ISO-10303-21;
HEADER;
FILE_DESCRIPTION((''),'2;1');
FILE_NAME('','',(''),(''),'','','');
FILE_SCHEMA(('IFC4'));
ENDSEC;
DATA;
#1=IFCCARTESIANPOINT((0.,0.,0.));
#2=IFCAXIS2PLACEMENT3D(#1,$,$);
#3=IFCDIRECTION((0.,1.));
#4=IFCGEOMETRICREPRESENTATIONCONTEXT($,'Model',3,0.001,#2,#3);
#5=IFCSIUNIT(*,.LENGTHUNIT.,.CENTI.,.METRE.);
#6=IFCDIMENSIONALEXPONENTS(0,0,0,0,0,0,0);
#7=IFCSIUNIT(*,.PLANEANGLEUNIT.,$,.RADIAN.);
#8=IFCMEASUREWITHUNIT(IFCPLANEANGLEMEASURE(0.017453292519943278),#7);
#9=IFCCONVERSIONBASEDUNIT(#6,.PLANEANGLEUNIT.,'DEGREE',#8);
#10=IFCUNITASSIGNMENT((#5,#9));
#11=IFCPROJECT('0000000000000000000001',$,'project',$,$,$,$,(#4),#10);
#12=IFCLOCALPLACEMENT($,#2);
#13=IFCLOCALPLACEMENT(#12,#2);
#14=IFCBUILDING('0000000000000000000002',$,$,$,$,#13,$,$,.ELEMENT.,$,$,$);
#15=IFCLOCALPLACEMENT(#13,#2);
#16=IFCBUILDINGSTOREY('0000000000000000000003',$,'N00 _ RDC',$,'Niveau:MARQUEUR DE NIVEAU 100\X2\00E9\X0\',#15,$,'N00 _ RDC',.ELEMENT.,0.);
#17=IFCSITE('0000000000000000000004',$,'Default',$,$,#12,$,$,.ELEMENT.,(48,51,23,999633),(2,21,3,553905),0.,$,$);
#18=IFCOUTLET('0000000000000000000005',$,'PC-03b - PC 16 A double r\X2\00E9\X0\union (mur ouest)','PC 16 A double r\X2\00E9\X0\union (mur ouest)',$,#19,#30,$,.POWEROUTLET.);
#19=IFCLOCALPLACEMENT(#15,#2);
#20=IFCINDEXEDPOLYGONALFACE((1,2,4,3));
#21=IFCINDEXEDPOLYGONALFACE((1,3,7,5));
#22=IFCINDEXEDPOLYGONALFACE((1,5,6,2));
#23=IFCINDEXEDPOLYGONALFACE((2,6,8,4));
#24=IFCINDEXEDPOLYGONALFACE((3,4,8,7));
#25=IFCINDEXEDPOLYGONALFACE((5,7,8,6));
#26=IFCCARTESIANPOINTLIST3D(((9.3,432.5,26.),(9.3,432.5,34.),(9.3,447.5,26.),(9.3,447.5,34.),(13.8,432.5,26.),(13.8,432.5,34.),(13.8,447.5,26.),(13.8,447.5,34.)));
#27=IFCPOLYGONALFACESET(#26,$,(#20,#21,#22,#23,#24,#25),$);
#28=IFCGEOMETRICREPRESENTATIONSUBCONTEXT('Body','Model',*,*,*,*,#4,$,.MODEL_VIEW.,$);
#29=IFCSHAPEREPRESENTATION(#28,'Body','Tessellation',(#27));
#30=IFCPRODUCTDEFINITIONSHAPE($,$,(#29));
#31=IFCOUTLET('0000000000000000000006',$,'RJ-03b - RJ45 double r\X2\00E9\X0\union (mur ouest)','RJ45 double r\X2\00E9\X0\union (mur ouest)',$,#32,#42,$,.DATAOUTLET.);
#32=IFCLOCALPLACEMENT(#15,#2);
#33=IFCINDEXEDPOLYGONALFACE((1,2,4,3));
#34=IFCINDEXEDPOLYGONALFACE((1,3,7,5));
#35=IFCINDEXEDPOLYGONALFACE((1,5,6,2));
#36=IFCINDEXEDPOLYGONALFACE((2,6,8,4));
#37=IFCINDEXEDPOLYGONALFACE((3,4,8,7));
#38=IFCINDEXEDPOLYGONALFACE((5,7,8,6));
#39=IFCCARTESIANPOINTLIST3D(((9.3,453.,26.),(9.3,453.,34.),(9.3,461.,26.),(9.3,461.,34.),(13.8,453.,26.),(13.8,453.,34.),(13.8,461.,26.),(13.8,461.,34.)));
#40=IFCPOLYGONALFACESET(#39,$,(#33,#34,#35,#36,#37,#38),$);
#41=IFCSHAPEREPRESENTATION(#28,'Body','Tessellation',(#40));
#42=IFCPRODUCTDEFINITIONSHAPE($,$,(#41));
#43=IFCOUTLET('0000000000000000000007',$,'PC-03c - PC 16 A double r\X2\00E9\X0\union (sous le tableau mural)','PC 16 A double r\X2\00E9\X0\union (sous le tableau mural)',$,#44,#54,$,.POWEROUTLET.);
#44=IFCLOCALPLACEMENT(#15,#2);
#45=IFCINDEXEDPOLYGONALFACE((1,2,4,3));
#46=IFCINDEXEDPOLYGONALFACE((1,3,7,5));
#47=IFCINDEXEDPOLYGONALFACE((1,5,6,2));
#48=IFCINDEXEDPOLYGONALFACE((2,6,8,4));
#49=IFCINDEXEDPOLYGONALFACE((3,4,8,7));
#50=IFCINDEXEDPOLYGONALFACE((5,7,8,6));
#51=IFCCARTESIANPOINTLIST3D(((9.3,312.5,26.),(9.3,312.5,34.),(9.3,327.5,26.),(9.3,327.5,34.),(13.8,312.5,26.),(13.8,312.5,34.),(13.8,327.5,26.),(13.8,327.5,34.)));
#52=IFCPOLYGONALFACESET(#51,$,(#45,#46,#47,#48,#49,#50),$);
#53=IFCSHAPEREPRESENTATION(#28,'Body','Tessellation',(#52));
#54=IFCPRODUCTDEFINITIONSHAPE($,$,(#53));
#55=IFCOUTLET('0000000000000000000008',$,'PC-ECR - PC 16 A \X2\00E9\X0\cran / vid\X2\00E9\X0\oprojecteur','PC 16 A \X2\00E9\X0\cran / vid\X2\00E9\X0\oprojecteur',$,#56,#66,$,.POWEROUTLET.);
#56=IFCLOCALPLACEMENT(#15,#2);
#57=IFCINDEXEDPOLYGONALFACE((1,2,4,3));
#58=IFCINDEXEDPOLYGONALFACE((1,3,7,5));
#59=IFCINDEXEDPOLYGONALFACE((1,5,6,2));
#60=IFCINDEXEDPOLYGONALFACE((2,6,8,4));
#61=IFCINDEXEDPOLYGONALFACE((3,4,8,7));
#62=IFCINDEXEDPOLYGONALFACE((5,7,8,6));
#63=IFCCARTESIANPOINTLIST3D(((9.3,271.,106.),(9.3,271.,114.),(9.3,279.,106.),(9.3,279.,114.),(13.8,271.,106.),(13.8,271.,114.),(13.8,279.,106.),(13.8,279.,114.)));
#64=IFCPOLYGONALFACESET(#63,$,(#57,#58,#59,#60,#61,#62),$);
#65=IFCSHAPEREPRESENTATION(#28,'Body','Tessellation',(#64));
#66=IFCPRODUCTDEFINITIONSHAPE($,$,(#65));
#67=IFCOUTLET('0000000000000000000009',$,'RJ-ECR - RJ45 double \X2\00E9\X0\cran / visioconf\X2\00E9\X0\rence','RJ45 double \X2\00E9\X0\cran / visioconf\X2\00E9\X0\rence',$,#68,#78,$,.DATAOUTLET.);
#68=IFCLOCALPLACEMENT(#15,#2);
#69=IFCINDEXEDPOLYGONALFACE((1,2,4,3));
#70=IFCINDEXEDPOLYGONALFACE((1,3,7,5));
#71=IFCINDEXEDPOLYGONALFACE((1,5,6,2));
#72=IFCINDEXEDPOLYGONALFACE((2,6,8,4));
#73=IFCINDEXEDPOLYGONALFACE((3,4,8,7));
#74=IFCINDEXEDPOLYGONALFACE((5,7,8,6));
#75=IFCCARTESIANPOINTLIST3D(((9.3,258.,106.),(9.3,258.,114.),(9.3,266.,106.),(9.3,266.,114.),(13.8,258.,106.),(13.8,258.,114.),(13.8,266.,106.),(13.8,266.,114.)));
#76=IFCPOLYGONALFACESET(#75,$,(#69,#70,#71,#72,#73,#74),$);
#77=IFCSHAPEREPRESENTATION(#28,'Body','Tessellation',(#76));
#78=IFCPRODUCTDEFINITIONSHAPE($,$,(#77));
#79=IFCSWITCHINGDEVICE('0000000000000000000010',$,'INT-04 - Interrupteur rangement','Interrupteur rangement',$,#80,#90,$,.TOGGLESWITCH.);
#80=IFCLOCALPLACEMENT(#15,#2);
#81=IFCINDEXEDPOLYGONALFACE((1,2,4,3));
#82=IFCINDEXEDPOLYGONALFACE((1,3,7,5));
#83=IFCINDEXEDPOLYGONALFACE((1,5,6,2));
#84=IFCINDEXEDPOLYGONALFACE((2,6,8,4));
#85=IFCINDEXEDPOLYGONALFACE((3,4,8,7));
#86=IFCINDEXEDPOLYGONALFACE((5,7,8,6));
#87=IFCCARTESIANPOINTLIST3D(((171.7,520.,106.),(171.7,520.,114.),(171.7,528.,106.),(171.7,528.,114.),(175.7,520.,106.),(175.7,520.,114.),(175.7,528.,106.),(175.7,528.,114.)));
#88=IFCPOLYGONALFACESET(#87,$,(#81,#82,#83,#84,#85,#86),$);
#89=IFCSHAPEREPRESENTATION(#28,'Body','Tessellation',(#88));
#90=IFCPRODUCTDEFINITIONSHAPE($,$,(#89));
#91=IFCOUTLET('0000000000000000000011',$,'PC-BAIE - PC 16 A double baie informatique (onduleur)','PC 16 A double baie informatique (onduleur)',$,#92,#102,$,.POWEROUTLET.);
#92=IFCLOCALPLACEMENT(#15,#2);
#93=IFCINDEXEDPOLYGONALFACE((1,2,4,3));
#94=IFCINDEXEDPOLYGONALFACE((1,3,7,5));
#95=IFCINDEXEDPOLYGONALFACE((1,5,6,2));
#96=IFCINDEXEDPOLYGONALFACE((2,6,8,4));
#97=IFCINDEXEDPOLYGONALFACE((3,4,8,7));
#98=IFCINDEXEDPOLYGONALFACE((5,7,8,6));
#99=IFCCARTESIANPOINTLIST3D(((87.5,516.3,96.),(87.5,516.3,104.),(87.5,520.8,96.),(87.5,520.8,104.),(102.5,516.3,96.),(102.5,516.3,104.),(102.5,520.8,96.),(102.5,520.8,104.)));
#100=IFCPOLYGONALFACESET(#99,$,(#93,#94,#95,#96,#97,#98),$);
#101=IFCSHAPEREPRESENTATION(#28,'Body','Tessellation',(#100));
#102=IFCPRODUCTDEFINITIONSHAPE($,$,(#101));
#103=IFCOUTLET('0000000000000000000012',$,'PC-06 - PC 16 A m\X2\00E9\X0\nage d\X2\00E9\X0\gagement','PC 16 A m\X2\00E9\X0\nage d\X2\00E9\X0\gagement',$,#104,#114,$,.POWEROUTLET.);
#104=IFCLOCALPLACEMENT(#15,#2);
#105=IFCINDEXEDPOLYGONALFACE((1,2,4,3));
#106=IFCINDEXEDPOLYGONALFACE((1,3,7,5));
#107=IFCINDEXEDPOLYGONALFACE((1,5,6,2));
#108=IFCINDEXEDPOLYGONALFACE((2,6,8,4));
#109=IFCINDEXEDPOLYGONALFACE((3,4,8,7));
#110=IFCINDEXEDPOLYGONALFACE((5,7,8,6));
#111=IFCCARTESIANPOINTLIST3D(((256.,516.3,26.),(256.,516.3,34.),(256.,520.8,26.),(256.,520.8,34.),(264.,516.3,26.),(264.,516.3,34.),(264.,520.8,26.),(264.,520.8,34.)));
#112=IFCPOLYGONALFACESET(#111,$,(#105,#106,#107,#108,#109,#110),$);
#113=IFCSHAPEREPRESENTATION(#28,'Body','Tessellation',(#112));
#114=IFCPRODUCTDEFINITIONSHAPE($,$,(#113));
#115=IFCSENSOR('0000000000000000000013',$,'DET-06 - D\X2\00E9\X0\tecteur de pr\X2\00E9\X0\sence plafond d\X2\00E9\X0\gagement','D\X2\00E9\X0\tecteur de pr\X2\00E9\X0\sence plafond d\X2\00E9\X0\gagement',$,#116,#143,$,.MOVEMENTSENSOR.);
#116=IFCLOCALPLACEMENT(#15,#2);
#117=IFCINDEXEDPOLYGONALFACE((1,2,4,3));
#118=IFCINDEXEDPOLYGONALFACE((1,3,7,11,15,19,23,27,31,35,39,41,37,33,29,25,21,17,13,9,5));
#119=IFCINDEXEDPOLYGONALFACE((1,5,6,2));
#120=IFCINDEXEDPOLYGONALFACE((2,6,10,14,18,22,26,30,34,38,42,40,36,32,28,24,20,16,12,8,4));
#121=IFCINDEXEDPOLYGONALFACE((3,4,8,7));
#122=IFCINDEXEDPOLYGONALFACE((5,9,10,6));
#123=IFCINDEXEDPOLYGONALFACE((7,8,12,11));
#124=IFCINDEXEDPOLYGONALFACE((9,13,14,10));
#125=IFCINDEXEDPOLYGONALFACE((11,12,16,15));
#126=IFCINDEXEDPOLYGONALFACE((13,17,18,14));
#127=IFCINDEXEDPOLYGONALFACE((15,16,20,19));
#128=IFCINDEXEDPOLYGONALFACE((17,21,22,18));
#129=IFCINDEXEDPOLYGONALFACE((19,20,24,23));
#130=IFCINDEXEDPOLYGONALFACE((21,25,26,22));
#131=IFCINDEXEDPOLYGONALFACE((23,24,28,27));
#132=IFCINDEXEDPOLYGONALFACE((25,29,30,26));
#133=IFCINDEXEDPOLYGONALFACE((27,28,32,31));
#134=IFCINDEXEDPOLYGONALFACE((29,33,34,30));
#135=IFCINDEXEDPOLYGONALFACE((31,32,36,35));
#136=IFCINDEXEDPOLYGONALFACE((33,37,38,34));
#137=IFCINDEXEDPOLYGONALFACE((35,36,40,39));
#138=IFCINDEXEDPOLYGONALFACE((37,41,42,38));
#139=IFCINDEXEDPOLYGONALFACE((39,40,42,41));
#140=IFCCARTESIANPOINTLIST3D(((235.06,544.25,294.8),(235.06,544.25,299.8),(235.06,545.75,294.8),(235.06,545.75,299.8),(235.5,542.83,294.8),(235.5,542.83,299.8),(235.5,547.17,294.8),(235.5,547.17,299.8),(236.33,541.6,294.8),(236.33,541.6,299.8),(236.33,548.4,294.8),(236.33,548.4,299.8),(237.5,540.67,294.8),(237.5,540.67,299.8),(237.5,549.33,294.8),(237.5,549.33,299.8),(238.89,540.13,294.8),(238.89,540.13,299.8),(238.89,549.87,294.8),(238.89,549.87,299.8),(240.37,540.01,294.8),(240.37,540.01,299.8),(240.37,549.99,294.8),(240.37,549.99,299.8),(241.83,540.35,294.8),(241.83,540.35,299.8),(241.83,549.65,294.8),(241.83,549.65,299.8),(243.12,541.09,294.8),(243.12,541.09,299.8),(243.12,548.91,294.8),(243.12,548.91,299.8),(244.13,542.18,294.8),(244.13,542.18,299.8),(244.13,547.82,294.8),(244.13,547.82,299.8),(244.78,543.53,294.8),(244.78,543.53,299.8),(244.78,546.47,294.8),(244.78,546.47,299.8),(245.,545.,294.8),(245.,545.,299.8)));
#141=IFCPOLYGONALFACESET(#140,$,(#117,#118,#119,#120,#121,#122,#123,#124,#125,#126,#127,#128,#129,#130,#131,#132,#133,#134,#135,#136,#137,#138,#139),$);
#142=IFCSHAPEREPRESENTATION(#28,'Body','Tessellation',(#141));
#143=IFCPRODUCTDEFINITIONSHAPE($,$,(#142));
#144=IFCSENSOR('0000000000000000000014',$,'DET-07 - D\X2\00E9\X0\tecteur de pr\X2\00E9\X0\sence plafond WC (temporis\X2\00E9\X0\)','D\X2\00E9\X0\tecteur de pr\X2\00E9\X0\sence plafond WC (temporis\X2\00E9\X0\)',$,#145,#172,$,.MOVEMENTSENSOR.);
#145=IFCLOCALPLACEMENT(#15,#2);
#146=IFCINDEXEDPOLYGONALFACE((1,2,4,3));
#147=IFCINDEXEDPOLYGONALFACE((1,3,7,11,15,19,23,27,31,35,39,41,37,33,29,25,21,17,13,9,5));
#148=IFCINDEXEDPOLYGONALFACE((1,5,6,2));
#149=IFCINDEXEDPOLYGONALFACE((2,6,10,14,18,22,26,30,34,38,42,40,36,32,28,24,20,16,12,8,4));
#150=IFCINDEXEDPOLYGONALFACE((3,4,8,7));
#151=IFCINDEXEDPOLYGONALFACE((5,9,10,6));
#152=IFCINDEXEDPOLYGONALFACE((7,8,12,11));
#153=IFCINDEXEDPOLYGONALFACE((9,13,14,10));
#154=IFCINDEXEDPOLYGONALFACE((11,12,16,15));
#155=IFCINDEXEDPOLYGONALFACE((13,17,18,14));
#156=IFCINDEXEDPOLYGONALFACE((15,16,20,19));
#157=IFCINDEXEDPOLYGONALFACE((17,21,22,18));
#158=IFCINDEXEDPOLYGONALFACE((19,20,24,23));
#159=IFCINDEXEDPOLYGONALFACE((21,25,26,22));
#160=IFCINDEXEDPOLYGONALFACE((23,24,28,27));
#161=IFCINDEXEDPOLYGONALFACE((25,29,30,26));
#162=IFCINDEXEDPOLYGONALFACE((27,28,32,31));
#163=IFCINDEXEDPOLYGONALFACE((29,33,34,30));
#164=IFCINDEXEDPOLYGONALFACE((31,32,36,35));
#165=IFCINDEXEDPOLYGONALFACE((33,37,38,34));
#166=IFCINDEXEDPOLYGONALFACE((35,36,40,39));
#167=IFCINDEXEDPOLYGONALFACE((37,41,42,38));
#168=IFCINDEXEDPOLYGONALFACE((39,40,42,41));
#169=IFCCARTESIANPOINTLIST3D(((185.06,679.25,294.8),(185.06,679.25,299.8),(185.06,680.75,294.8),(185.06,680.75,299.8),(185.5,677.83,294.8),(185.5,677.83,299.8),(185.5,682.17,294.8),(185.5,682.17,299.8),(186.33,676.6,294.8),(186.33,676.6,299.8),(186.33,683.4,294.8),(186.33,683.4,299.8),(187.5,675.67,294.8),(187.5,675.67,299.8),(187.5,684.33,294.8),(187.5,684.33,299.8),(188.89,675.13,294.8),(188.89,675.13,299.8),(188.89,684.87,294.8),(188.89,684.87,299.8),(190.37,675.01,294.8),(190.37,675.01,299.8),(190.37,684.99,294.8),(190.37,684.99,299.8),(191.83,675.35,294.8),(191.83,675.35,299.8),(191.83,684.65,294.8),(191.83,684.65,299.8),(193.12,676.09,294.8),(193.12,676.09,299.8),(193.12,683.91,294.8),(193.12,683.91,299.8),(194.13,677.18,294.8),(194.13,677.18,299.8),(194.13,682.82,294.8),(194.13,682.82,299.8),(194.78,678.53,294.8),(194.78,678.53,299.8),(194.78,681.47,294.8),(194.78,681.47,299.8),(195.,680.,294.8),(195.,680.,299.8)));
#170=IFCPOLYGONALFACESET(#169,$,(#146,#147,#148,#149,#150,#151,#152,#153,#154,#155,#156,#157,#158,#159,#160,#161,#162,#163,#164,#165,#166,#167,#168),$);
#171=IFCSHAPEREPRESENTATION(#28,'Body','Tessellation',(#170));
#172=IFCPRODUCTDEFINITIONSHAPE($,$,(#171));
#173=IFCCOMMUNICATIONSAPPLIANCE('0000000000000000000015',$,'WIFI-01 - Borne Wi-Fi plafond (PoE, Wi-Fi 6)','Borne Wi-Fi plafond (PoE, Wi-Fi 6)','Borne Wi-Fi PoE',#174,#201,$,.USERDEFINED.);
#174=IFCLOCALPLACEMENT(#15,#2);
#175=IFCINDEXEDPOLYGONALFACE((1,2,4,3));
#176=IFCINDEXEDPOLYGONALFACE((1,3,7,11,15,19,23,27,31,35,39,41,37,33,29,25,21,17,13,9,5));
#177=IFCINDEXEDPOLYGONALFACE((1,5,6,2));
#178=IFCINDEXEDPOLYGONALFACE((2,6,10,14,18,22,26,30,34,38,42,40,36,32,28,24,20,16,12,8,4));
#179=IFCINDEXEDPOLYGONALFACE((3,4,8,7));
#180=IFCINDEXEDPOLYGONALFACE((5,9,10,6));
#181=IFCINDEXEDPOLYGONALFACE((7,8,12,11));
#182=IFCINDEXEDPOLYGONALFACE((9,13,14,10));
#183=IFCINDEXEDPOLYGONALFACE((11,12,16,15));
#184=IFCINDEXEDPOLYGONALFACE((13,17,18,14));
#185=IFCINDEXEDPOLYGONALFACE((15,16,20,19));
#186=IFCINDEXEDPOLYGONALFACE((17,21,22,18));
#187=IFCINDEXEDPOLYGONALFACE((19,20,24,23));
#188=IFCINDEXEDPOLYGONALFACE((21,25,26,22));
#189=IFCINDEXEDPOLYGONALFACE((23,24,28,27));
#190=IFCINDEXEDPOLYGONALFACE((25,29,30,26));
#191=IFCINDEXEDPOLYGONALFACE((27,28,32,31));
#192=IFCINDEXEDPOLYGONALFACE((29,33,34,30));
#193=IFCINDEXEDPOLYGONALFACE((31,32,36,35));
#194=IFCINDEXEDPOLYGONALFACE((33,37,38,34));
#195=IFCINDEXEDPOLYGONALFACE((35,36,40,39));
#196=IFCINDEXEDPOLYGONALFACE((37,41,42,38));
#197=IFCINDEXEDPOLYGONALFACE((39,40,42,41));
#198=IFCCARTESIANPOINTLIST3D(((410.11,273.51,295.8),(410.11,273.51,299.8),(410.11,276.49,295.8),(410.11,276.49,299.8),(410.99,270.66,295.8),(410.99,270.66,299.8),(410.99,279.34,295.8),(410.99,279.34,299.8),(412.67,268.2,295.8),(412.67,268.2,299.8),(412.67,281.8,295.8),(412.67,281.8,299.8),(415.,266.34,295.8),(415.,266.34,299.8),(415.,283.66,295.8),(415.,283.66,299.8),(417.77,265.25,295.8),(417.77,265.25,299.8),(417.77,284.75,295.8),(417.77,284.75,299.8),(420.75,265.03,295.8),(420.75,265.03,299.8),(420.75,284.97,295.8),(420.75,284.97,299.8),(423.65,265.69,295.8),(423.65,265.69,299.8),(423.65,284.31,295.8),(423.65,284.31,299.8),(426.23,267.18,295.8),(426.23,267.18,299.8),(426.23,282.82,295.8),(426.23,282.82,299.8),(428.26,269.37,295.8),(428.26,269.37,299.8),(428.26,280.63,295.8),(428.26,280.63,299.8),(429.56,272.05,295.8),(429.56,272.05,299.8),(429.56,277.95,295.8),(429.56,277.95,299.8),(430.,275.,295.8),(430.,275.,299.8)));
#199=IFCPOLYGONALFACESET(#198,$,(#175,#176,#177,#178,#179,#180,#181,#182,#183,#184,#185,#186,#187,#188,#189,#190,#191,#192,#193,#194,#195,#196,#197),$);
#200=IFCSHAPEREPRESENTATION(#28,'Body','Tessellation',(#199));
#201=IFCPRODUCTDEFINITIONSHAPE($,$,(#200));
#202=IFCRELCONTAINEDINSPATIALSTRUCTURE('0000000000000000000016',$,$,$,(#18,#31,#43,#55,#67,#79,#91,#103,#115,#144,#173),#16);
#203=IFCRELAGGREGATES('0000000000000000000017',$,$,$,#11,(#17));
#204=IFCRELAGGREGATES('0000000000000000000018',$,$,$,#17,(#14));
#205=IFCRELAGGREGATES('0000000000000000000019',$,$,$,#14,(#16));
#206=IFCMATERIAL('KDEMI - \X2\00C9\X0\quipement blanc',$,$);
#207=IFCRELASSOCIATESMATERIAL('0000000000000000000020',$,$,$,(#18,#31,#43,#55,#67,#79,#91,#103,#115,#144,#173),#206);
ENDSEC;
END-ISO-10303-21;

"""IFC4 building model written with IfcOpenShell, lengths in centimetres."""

from ifc_helpers import new_model, entity, si_unit, converted_unit, direction, frame, frame_2d, origin, origin_with_axes, place, context, subcontext, project, spatial, rectangle, circle, extrude, material, element, save


model = new_model("IFC4")

# Units and contexts
model_context = context("Model", 3, precision=0.001, world=origin(), true_north=direction((0.0, 1.0)))
body_context = subcontext(model_context, "Body", "Model", "MODEL_VIEW")
ifc_project = project(units=[si_unit("LENGTHUNIT", "METRE", prefix="CENTI"), converted_unit("PLANEANGLEUNIT", "DEGREE", entity("IfcPlaneAngleMeasure", 0.017453292519943278), si_unit("PLANEANGLEUNIT", "RADIAN"), dimensions=[0, 0, 0, 0, 0, 0, 0])], contexts=[model_context])

# Site, building, storey
site_placement = place(None, origin())
site = spatial("IfcSite", under=ifc_project, at=site_placement, Name="Default", CompositionType="ELEMENT", RefLatitude=(48, 51, 23, 999633), RefLongitude=(2, 21, 3, 553905), RefElevation=0.0)
building_placement = place(site_placement, origin())
building = spatial("IfcBuilding", under=site, at=building_placement, CompositionType="ELEMENT")
storey_placement = place(building_placement, origin())
storey = spatial("IfcBuildingStorey", under=building, at=storey_placement, Name="N00 _ RDC", ObjectType="Niveau:MARQUEUR DE NIVEAU 100é", LongName="N00 _ RDC", CompositionType="ELEMENT", Elevation=0.0)

# Shared definitions
ifc_material_1 = material(Name="KDEMI - Équipement blanc")

# Outlets
outlet_1_placement = place(storey_placement, origin_with_axes())
element("IfcOutlet", 1, at=outlet_1_placement, inside=storey, material=ifc_material_1, Name="PC-03b - PC 16 A double réunion (mur ouest)", Description="PC 16 A double réunion (mur ouest)", PredefinedType="POWEROUTLET", context=body_context, shape_type="SweptSolid", body=[
    extrude(rectangle(XDim=4.5, YDim=15.0, at=frame_2d((11.55, 440.0))), frame((0.0, 0.0, 26.0)), (0.0, 0.0, 1.0), 8.0),
])
outlet_2_placement = place(storey_placement, origin_with_axes())
element("IfcOutlet", 2, at=outlet_2_placement, inside=storey, material=ifc_material_1, Name="RJ-03b - RJ45 double réunion (mur ouest)", Description="RJ45 double réunion (mur ouest)", PredefinedType="DATAOUTLET", context=body_context, shape_type="SweptSolid", body=[
    extrude(rectangle(XDim=4.5, YDim=8.0, at=frame_2d((11.55, 457.0))), frame((0.0, 0.0, 26.0)), (0.0, 0.0, 1.0), 8.0),
])
outlet_3_placement = place(storey_placement, origin_with_axes())
element("IfcOutlet", 3, at=outlet_3_placement, inside=storey, material=ifc_material_1, Name="PC-03c - PC 16 A double réunion (sous le tableau mural)", Description="PC 16 A double réunion (sous le tableau mural)", PredefinedType="POWEROUTLET", context=body_context, shape_type="SweptSolid", body=[
    extrude(rectangle(XDim=4.5, YDim=15.0, at=frame_2d((11.55, 320.0))), frame((0.0, 0.0, 26.0)), (0.0, 0.0, 1.0), 8.0),
])
outlet_4_placement = place(storey_placement, origin_with_axes())
element("IfcOutlet", 4, at=outlet_4_placement, inside=storey, material=ifc_material_1, Name="PC-ECR - PC 16 A écran / vidéoprojecteur", Description="PC 16 A écran / vidéoprojecteur", PredefinedType="POWEROUTLET", context=body_context, shape_type="SweptSolid", body=[
    extrude(rectangle(XDim=4.5, YDim=8.0, at=frame_2d((11.55, 275.0))), frame((0.0, 0.0, 106.0)), (0.0, 0.0, 1.0), 8.0),
])
outlet_5_placement = place(storey_placement, origin_with_axes())
element("IfcOutlet", 5, at=outlet_5_placement, inside=storey, material=ifc_material_1, Name="RJ-ECR - RJ45 double écran / visioconférence", Description="RJ45 double écran / visioconférence", PredefinedType="DATAOUTLET", context=body_context, shape_type="SweptSolid", body=[
    extrude(rectangle(XDim=4.5, YDim=8.0, at=frame_2d((11.55, 262.0))), frame((0.0, 0.0, 106.0)), (0.0, 0.0, 1.0), 8.0),
])

# Switching device
switching_device_1_placement = place(storey_placement, origin_with_axes())
element("IfcSwitchingDevice", 6, at=switching_device_1_placement, inside=storey, material=ifc_material_1, Name="INT-04 - Interrupteur rangement", Description="Interrupteur rangement", PredefinedType="TOGGLESWITCH", context=body_context, shape_type="SweptSolid", body=[
    extrude(rectangle(XDim=4.0, YDim=8.0, at=frame_2d((173.7, 524.0))), frame((0.0, 0.0, 106.0)), (0.0, 0.0, 1.0), 8.0),
])

# Outlets
outlet_6_placement = place(storey_placement, origin_with_axes())
element("IfcOutlet", 7, at=outlet_6_placement, inside=storey, material=ifc_material_1, Name="PC-BAIE - PC 16 A double baie informatique (onduleur)", Description="PC 16 A double baie informatique (onduleur)", PredefinedType="POWEROUTLET", context=body_context, shape_type="SweptSolid", body=[
    extrude(rectangle(XDim=15.0, YDim=4.5, at=frame_2d((95.0, 518.55))), frame((0.0, 0.0, 96.0)), (0.0, 0.0, 1.0), 8.0),
])
outlet_7_placement = place(storey_placement, origin_with_axes())
element("IfcOutlet", 8, at=outlet_7_placement, inside=storey, material=ifc_material_1, Name="PC-06 - PC 16 A ménage dégagement", Description="PC 16 A ménage dégagement", PredefinedType="POWEROUTLET", context=body_context, shape_type="SweptSolid", body=[
    extrude(rectangle(XDim=8.0, YDim=4.5, at=frame_2d((260.0, 518.55))), frame((0.0, 0.0, 26.0)), (0.0, 0.0, 1.0), 8.0),
])

# Sensors
sensor_1_placement = place(storey_placement, origin_with_axes())
element("IfcSensor", 9, at=sensor_1_placement, inside=storey, material=ifc_material_1, Name="DET-06 - Détecteur de présence plafond dégagement", Description="Détecteur de présence plafond dégagement", PredefinedType="MOVEMENTSENSOR", context=body_context, shape_type="SweptSolid", body=[
    extrude(circle(Radius=5.0, at=frame_2d((240.0, 545.0))), frame((0.0, 0.0, 294.8)), (0.0, 0.0, 1.0), 5.0),
])
sensor_2_placement = place(storey_placement, origin_with_axes())
element("IfcSensor", 10, at=sensor_2_placement, inside=storey, material=ifc_material_1, Name="DET-07 - Détecteur de présence plafond WC (temporisé)", Description="Détecteur de présence plafond WC (temporisé)", PredefinedType="MOVEMENTSENSOR", context=body_context, shape_type="SweptSolid", body=[
    extrude(circle(Radius=5.0, at=frame_2d((190.0, 680.0))), frame((0.0, 0.0, 294.8)), (0.0, 0.0, 1.0), 5.0),
])

# Communications appliance
communications_appliance_placement = place(storey_placement, origin_with_axes())
element("IfcCommunicationsAppliance", 11, at=communications_appliance_placement, inside=storey, material=ifc_material_1, Name="WIFI-01 - Borne Wi-Fi plafond (PoE, Wi-Fi 6)", Description="Borne Wi-Fi plafond (PoE, Wi-Fi 6)", ObjectType="Borne Wi-Fi PoE", PredefinedType="USERDEFINED", context=body_context, shape_type="SweptSolid", body=[
    extrude(circle(Radius=10.0, at=frame_2d((420.0, 275.0))), frame((0.0, 0.0, 295.8)), (0.0, 0.0, 1.0), 4.0),
])

save(model, "model.ifc")
